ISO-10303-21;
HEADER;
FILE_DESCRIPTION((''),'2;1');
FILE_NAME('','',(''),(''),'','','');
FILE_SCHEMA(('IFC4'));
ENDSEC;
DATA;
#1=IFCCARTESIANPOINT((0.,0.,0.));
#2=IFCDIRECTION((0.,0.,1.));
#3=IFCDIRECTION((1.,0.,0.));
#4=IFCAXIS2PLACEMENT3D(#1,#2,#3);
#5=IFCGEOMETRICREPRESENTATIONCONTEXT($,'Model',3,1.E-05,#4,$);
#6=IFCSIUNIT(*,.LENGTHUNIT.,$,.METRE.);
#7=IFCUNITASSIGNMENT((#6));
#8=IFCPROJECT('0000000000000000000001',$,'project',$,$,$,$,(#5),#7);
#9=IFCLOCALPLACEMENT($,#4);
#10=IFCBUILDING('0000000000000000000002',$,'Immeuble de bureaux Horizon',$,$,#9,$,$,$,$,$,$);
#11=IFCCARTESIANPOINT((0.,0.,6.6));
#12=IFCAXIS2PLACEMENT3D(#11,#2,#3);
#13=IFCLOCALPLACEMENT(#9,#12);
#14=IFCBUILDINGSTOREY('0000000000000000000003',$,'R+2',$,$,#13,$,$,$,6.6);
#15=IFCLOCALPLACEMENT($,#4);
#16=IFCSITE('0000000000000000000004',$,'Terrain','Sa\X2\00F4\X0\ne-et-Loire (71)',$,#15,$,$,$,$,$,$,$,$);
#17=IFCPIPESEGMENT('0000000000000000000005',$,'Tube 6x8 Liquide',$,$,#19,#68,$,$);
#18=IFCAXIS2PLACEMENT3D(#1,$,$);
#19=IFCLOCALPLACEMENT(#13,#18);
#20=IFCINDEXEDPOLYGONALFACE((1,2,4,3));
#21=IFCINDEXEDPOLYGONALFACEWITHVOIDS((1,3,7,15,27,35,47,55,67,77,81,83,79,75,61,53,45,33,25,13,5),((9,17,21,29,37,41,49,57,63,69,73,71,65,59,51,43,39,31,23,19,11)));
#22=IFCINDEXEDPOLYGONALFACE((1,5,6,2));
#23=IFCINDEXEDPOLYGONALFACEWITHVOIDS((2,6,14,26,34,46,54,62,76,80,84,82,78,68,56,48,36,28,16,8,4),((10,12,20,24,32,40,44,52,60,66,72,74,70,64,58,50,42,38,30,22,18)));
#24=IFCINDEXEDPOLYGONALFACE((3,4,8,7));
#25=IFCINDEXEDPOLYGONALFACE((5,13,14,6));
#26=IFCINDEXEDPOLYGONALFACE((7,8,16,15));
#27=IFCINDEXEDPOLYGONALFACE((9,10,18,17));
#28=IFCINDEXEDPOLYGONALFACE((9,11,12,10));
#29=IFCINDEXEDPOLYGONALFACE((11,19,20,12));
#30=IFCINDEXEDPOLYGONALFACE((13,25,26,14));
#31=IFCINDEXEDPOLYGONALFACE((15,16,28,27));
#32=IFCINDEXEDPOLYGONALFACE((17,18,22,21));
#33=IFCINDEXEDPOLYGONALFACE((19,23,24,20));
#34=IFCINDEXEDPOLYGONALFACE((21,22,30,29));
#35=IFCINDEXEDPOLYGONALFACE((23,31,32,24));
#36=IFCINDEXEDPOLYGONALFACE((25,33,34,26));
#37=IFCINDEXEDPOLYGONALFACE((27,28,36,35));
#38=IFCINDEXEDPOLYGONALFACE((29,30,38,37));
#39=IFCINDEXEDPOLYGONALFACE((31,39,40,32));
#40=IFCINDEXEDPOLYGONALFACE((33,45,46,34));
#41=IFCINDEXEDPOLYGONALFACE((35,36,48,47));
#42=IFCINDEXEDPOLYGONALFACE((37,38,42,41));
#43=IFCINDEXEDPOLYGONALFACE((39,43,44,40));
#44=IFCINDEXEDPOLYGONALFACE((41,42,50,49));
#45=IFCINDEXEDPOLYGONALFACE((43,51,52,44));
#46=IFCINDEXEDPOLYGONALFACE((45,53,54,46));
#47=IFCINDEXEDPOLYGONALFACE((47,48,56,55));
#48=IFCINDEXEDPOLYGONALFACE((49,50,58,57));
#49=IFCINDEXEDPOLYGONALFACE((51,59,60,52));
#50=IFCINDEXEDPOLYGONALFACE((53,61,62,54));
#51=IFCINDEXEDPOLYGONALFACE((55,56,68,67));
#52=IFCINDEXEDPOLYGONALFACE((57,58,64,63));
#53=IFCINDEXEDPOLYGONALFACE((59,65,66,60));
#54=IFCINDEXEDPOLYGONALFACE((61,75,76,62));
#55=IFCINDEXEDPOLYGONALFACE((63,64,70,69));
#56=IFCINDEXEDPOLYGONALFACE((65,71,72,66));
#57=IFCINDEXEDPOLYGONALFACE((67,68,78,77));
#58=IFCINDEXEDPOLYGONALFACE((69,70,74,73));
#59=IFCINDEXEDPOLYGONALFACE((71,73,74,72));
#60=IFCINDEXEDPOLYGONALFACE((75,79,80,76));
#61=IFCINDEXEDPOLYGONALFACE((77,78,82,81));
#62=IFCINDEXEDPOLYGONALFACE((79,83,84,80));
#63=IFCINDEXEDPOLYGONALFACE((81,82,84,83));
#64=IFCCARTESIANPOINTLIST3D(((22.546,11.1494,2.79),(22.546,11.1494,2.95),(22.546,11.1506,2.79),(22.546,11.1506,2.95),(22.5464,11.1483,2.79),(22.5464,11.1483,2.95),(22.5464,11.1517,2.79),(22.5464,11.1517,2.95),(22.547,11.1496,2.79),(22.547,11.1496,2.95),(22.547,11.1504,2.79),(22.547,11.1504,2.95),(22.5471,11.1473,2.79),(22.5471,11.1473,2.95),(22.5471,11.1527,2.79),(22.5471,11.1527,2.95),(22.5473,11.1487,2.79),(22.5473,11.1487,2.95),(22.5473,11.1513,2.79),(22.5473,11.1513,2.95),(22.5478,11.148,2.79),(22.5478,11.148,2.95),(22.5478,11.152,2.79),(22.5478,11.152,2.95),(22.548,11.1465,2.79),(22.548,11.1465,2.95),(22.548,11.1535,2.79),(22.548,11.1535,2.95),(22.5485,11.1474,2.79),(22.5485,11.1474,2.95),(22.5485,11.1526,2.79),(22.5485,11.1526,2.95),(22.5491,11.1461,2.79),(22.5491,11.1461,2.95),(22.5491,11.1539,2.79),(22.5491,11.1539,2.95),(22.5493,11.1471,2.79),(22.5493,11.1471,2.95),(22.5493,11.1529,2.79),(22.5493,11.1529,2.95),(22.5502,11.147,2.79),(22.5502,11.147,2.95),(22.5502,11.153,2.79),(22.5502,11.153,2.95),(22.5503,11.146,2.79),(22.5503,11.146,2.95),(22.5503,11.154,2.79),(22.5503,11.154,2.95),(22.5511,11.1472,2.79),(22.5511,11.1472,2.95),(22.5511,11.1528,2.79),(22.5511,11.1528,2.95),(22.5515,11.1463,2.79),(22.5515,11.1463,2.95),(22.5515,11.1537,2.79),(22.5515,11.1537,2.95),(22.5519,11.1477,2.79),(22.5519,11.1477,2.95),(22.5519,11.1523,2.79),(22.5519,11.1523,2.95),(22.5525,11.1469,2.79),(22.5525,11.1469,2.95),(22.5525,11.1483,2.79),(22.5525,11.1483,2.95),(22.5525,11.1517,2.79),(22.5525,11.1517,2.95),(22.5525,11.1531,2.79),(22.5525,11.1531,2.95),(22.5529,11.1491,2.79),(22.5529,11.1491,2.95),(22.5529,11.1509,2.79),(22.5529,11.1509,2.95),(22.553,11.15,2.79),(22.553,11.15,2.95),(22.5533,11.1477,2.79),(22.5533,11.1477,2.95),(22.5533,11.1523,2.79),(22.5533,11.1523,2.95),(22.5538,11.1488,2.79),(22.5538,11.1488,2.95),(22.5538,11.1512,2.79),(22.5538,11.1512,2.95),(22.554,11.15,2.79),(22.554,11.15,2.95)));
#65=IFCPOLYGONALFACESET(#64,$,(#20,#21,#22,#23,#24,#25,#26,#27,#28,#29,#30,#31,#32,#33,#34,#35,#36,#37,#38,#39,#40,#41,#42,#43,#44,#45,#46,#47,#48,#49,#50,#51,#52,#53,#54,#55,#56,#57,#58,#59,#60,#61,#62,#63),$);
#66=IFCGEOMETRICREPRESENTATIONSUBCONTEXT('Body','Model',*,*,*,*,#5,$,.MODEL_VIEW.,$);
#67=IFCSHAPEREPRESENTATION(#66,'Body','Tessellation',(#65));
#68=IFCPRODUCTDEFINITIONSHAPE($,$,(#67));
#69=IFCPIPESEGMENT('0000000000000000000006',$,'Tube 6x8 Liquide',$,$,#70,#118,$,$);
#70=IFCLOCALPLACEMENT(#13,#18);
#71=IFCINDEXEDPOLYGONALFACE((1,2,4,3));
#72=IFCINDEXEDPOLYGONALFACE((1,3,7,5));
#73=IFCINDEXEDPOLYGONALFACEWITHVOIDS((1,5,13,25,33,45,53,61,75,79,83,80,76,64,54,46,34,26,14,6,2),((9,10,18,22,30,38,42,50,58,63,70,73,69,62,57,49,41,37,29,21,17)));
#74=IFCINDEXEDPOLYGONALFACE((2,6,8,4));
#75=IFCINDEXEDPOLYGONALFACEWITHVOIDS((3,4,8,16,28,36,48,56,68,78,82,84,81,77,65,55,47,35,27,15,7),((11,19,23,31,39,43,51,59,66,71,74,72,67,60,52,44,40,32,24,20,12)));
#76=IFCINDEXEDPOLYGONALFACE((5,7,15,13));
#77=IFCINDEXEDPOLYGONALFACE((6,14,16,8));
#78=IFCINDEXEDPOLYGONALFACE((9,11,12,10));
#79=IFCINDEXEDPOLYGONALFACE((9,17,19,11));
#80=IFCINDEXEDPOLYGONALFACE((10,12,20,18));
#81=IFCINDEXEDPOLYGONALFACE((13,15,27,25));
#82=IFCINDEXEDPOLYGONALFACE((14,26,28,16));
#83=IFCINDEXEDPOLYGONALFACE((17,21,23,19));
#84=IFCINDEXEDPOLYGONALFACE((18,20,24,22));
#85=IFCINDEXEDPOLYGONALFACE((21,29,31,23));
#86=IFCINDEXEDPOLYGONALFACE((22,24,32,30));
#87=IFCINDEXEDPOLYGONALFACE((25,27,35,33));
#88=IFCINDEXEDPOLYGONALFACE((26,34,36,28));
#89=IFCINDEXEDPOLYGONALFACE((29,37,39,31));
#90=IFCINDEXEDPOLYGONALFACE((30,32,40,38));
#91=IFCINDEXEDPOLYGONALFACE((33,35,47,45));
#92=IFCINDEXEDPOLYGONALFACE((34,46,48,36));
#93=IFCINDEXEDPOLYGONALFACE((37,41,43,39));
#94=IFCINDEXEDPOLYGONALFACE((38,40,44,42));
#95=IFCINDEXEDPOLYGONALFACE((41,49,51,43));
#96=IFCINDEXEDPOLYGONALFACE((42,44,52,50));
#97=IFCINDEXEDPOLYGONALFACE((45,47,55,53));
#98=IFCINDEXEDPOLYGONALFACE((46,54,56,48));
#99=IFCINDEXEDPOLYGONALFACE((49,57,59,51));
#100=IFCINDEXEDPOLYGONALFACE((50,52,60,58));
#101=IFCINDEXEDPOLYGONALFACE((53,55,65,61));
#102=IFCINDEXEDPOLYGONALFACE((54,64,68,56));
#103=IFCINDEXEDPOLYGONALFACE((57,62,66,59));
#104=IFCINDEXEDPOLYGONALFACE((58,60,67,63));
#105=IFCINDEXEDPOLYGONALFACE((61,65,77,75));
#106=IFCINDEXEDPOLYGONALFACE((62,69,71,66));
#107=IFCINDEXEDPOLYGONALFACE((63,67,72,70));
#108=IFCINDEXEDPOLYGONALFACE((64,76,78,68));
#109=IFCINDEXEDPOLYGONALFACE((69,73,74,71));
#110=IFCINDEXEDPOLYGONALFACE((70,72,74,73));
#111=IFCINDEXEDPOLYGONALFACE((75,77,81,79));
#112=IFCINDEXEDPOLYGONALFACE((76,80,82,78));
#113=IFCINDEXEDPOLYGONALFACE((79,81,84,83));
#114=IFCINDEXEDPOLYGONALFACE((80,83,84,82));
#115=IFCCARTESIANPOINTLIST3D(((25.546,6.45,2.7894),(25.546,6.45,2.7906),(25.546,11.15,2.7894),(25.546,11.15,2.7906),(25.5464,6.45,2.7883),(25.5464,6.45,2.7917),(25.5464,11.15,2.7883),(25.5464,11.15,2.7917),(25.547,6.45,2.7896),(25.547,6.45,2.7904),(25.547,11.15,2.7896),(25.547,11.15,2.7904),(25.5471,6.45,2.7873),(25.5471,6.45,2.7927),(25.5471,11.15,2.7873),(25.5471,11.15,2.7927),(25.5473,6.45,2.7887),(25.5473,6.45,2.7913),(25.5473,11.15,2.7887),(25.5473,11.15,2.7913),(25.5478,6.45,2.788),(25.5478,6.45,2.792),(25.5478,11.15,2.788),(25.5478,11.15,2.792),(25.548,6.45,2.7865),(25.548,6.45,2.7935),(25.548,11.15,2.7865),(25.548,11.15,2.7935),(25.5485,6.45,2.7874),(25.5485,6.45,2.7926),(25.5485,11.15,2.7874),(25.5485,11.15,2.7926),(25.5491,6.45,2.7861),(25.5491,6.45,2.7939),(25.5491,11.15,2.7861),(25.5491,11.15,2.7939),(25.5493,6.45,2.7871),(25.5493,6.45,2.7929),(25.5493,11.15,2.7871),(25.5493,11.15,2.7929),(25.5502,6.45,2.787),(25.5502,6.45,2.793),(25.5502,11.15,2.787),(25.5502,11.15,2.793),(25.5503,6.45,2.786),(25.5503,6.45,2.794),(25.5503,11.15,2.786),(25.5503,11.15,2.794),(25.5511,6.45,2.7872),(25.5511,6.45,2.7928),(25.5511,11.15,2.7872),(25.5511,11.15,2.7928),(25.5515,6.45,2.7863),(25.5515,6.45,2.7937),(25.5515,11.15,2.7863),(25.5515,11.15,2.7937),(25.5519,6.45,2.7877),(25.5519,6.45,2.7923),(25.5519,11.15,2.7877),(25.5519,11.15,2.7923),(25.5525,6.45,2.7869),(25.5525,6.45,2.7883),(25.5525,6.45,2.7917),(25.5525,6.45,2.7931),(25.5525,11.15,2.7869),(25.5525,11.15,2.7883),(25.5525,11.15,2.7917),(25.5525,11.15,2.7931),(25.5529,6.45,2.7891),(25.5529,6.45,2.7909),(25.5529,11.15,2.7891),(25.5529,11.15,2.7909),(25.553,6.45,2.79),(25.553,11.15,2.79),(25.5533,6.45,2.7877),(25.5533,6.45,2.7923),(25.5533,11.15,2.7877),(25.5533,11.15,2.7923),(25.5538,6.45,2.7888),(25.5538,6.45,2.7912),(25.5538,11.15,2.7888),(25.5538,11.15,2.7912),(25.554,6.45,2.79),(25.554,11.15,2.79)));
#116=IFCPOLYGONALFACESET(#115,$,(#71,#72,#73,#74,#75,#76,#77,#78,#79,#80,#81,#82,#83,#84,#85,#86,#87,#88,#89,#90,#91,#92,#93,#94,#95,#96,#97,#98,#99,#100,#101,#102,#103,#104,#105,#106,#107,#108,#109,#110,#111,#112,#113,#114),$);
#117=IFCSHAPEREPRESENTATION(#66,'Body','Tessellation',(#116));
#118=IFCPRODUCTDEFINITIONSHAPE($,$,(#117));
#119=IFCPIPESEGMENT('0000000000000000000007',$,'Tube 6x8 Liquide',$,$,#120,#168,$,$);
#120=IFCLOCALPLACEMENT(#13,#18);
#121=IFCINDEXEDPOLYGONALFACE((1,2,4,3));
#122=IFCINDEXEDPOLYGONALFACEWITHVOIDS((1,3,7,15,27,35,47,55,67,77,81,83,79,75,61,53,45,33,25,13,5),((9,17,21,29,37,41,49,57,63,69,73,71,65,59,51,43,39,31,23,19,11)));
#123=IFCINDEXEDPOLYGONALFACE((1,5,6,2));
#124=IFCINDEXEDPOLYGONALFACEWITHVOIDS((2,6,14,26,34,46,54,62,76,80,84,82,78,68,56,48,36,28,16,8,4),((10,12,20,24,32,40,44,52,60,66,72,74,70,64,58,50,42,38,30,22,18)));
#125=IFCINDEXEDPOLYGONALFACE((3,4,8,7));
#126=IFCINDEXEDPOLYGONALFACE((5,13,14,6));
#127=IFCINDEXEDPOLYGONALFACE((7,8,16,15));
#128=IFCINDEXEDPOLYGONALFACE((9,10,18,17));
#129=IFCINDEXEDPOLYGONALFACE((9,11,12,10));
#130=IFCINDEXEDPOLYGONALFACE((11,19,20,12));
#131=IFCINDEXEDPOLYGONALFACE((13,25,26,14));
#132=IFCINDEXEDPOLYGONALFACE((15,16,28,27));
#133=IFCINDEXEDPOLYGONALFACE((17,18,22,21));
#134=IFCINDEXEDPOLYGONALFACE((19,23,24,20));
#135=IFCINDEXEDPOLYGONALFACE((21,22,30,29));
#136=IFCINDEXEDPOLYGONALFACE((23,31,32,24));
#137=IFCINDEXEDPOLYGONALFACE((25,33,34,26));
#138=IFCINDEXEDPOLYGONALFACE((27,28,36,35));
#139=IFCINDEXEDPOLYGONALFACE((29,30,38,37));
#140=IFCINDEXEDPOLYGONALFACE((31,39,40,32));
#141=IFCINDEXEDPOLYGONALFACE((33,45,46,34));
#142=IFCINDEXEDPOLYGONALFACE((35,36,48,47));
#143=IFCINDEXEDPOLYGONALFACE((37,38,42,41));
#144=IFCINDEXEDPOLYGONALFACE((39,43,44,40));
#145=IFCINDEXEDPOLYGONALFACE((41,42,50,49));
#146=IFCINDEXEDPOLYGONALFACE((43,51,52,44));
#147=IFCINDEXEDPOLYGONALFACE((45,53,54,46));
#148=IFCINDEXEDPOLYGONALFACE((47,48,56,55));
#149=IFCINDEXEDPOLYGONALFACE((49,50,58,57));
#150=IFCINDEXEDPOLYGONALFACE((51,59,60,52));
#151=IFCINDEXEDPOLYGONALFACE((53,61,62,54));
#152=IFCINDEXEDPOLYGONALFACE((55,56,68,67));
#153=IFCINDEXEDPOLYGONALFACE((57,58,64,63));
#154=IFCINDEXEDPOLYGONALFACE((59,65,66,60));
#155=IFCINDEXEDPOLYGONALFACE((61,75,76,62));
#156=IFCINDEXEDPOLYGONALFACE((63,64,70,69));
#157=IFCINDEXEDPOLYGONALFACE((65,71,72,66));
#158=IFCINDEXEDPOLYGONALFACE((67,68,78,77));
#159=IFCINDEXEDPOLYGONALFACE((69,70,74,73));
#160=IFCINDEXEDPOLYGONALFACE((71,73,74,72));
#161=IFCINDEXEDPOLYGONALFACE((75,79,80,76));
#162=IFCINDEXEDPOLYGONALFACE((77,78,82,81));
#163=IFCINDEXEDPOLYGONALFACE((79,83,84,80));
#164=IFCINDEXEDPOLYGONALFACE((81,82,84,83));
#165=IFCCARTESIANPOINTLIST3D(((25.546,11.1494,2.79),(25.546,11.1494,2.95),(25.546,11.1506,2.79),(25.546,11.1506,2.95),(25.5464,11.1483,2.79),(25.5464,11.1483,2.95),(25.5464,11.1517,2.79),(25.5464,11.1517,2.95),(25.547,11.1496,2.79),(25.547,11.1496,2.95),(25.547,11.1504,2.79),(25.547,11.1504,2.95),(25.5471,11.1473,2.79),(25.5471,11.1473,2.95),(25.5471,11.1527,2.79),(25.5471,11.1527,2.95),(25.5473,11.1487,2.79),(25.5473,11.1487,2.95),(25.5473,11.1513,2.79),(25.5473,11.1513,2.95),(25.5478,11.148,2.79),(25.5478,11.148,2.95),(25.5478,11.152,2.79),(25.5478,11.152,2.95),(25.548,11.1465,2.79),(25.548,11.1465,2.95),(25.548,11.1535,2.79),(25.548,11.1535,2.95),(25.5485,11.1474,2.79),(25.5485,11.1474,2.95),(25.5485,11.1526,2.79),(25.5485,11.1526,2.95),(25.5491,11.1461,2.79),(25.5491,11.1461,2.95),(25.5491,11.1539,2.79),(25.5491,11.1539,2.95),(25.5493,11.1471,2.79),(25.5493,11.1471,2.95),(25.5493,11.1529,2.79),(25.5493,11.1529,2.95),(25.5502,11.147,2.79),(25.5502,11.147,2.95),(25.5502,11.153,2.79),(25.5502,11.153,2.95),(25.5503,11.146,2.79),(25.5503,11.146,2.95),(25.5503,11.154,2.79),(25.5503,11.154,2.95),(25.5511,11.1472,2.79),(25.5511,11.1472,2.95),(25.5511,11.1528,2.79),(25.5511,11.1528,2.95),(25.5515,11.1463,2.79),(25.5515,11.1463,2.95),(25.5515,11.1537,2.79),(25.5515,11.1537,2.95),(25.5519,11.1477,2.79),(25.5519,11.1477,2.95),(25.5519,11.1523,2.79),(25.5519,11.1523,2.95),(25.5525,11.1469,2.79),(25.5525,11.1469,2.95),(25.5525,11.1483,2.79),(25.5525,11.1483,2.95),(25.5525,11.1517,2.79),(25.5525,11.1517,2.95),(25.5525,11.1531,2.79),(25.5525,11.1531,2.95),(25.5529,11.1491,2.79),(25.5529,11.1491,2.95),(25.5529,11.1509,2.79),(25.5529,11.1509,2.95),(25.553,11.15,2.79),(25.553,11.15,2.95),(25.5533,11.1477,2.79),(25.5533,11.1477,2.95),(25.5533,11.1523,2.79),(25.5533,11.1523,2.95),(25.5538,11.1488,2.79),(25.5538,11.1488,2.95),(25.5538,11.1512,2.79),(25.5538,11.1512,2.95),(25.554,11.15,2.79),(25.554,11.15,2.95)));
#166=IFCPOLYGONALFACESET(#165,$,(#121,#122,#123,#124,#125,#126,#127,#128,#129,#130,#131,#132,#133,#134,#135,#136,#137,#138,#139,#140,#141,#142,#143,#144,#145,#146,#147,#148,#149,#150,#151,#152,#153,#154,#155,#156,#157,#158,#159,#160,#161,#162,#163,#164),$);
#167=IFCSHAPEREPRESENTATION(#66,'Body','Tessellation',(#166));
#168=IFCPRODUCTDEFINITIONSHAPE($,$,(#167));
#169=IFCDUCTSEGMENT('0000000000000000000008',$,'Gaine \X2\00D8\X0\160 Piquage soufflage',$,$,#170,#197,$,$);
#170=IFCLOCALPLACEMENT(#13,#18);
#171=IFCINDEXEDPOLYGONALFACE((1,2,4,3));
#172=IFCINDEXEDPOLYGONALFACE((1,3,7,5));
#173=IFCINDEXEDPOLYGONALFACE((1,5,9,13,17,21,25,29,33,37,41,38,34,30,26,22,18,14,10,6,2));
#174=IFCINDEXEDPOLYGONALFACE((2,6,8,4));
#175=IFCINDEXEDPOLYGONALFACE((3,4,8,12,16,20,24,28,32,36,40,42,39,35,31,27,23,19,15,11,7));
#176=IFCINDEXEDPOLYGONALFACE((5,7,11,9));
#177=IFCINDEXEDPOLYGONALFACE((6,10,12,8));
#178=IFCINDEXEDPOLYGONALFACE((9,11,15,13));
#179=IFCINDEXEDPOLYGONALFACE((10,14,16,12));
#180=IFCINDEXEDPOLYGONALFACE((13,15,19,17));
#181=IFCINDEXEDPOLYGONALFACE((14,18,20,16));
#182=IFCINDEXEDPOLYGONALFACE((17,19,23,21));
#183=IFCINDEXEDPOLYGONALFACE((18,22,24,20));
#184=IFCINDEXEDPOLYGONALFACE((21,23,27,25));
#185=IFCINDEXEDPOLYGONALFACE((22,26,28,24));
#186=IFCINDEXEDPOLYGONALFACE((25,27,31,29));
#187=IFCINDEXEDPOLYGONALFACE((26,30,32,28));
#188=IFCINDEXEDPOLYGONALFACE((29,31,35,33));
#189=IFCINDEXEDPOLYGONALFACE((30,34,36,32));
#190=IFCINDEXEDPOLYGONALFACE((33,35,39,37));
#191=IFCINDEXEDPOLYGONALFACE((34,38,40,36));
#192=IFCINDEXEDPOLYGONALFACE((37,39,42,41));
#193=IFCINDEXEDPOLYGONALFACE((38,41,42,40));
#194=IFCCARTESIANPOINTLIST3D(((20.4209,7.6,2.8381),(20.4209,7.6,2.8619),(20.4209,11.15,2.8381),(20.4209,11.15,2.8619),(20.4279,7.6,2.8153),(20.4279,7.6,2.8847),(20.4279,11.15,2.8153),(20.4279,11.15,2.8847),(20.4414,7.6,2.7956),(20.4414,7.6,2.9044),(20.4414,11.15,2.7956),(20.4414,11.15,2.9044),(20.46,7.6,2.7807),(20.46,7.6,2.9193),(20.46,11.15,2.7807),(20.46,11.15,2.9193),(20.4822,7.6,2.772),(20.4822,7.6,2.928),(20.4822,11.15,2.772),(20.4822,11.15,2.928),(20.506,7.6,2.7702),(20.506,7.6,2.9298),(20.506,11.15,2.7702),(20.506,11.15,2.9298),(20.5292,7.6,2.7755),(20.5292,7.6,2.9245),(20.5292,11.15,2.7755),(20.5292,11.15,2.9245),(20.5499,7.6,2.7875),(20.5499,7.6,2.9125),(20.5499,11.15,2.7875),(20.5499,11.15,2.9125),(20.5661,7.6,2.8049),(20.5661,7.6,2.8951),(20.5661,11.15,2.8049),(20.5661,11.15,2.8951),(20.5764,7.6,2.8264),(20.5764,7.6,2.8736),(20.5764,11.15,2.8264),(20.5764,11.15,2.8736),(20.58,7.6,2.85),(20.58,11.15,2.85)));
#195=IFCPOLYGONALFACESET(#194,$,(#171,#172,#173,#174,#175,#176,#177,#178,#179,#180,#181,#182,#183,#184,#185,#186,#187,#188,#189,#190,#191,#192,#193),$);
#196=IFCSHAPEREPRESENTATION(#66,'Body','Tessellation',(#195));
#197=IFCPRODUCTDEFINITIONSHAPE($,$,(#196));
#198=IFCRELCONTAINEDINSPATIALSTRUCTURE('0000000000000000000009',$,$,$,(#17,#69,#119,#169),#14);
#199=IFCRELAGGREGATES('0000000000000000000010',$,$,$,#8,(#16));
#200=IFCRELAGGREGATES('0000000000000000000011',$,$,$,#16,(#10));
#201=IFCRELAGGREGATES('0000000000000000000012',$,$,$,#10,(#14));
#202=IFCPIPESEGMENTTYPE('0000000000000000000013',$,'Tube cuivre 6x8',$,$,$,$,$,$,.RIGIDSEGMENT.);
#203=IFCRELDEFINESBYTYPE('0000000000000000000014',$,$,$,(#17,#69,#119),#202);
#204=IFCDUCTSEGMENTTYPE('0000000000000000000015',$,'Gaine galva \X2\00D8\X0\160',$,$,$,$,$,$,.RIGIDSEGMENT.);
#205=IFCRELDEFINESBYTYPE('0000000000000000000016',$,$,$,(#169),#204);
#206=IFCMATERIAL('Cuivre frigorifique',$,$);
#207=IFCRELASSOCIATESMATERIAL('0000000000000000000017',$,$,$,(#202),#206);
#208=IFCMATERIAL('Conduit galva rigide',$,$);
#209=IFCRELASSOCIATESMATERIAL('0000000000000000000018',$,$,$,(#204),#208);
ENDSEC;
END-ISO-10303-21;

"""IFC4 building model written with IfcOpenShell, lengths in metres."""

from ifc_helpers import new_model, si_unit, frame, origin_with_axes, place, context, subcontext, project, spatial, circle, hollow_circle, extrude, material, type_object, element, save


model = new_model("IFC4")

# Units and contexts
model_context = context("Model", 3, precision=1e-05, world=origin_with_axes())
body_context = subcontext(model_context, "Body", "Model", "MODEL_VIEW")
ifc_project = project(units=[si_unit("LENGTHUNIT", "METRE")], contexts=[model_context])

# Site, building, storey
site_placement = place(None, origin_with_axes())
site = spatial("IfcSite", under=ifc_project, at=site_placement, Name="Terrain", Description="Saône-et-Loire (71)")
building_placement = place(None, origin_with_axes())
building = spatial("IfcBuilding", under=site, at=building_placement, Name="Immeuble de bureaux Horizon")
storey_placement = place(building_placement, frame((0.0, 0.0, 6.6), z_axis=(0.0, 0.0, 1.0), x_axis=(1.0, 0.0, 0.0)))
storey = spatial("IfcBuildingStorey", under=building, at=storey_placement, Name="R+2", Elevation=6.6)

# Pipe segments
ifc_material_1 = material(Name="Cuivre frigorifique")
pipe_segment_type_1 = type_object("IfcPipeSegmentType", Name="Tube cuivre 6x8", PredefinedType="RIGIDSEGMENT", material=ifc_material_1)
pipe_segment_1_placement = place(storey_placement, frame((22.55, 11.15, 2.79), z_axis=(0.0, 0.0, 1.0), x_axis=(1.0, 0.0, 0.0)))
element("IfcPipeSegment", 1, at=pipe_segment_1_placement, inside=storey, type_object=pipe_segment_type_1, Name="Tube 6x8 Liquide", context=body_context, shape_type="SweptSolid", body=[
    extrude(hollow_circle(Radius=0.004, WallThickness=0.001), origin_with_axes(), (0.0, 0.0, 1.0), 0.16),
])
pipe_segment_2_placement = place(storey_placement, frame((25.55, 6.45, 2.79), z_axis=(0.0, 1.0, 0.0), x_axis=(1.0, 0.0, 0.0)))
element("IfcPipeSegment", 2, at=pipe_segment_2_placement, inside=storey, type_object=pipe_segment_type_1, Name="Tube 6x8 Liquide", context=body_context, shape_type="SweptSolid", body=[
    extrude(hollow_circle(Radius=0.004, WallThickness=0.001), origin_with_axes(), (0.0, 0.0, 1.0), 4.7),
])
pipe_segment_3_placement = place(storey_placement, frame((25.55, 11.15, 2.79), z_axis=(0.0, 0.0, 1.0), x_axis=(1.0, 0.0, 0.0)))
element("IfcPipeSegment", 3, at=pipe_segment_3_placement, inside=storey, type_object=pipe_segment_type_1, Name="Tube 6x8 Liquide", context=body_context, shape_type="SweptSolid", body=[
    extrude(hollow_circle(Radius=0.004, WallThickness=0.001), origin_with_axes(), (0.0, 0.0, 1.0), 0.16),
])

# Duct segment
ifc_material_2 = material(Name="Conduit galva rigide")
duct_segment_type = type_object("IfcDuctSegmentType", Name="Gaine galva Ø160", PredefinedType="RIGIDSEGMENT", material=ifc_material_2)
duct_segment_1_placement = place(storey_placement, frame((20.5, 11.15, 2.85), z_axis=(0.0, -1.0, 0.0), x_axis=(1.0, 0.0, 0.0)))
element("IfcDuctSegment", 4, at=duct_segment_1_placement, inside=storey, type_object=duct_segment_type, Name="Gaine Ø160 Piquage soufflage", context=body_context, shape_type="SweptSolid", body=[
    extrude(circle(Radius=0.08), origin_with_axes(), (0.0, 0.0, 1.0), 3.55),
])

save(model, "model.ifc")
